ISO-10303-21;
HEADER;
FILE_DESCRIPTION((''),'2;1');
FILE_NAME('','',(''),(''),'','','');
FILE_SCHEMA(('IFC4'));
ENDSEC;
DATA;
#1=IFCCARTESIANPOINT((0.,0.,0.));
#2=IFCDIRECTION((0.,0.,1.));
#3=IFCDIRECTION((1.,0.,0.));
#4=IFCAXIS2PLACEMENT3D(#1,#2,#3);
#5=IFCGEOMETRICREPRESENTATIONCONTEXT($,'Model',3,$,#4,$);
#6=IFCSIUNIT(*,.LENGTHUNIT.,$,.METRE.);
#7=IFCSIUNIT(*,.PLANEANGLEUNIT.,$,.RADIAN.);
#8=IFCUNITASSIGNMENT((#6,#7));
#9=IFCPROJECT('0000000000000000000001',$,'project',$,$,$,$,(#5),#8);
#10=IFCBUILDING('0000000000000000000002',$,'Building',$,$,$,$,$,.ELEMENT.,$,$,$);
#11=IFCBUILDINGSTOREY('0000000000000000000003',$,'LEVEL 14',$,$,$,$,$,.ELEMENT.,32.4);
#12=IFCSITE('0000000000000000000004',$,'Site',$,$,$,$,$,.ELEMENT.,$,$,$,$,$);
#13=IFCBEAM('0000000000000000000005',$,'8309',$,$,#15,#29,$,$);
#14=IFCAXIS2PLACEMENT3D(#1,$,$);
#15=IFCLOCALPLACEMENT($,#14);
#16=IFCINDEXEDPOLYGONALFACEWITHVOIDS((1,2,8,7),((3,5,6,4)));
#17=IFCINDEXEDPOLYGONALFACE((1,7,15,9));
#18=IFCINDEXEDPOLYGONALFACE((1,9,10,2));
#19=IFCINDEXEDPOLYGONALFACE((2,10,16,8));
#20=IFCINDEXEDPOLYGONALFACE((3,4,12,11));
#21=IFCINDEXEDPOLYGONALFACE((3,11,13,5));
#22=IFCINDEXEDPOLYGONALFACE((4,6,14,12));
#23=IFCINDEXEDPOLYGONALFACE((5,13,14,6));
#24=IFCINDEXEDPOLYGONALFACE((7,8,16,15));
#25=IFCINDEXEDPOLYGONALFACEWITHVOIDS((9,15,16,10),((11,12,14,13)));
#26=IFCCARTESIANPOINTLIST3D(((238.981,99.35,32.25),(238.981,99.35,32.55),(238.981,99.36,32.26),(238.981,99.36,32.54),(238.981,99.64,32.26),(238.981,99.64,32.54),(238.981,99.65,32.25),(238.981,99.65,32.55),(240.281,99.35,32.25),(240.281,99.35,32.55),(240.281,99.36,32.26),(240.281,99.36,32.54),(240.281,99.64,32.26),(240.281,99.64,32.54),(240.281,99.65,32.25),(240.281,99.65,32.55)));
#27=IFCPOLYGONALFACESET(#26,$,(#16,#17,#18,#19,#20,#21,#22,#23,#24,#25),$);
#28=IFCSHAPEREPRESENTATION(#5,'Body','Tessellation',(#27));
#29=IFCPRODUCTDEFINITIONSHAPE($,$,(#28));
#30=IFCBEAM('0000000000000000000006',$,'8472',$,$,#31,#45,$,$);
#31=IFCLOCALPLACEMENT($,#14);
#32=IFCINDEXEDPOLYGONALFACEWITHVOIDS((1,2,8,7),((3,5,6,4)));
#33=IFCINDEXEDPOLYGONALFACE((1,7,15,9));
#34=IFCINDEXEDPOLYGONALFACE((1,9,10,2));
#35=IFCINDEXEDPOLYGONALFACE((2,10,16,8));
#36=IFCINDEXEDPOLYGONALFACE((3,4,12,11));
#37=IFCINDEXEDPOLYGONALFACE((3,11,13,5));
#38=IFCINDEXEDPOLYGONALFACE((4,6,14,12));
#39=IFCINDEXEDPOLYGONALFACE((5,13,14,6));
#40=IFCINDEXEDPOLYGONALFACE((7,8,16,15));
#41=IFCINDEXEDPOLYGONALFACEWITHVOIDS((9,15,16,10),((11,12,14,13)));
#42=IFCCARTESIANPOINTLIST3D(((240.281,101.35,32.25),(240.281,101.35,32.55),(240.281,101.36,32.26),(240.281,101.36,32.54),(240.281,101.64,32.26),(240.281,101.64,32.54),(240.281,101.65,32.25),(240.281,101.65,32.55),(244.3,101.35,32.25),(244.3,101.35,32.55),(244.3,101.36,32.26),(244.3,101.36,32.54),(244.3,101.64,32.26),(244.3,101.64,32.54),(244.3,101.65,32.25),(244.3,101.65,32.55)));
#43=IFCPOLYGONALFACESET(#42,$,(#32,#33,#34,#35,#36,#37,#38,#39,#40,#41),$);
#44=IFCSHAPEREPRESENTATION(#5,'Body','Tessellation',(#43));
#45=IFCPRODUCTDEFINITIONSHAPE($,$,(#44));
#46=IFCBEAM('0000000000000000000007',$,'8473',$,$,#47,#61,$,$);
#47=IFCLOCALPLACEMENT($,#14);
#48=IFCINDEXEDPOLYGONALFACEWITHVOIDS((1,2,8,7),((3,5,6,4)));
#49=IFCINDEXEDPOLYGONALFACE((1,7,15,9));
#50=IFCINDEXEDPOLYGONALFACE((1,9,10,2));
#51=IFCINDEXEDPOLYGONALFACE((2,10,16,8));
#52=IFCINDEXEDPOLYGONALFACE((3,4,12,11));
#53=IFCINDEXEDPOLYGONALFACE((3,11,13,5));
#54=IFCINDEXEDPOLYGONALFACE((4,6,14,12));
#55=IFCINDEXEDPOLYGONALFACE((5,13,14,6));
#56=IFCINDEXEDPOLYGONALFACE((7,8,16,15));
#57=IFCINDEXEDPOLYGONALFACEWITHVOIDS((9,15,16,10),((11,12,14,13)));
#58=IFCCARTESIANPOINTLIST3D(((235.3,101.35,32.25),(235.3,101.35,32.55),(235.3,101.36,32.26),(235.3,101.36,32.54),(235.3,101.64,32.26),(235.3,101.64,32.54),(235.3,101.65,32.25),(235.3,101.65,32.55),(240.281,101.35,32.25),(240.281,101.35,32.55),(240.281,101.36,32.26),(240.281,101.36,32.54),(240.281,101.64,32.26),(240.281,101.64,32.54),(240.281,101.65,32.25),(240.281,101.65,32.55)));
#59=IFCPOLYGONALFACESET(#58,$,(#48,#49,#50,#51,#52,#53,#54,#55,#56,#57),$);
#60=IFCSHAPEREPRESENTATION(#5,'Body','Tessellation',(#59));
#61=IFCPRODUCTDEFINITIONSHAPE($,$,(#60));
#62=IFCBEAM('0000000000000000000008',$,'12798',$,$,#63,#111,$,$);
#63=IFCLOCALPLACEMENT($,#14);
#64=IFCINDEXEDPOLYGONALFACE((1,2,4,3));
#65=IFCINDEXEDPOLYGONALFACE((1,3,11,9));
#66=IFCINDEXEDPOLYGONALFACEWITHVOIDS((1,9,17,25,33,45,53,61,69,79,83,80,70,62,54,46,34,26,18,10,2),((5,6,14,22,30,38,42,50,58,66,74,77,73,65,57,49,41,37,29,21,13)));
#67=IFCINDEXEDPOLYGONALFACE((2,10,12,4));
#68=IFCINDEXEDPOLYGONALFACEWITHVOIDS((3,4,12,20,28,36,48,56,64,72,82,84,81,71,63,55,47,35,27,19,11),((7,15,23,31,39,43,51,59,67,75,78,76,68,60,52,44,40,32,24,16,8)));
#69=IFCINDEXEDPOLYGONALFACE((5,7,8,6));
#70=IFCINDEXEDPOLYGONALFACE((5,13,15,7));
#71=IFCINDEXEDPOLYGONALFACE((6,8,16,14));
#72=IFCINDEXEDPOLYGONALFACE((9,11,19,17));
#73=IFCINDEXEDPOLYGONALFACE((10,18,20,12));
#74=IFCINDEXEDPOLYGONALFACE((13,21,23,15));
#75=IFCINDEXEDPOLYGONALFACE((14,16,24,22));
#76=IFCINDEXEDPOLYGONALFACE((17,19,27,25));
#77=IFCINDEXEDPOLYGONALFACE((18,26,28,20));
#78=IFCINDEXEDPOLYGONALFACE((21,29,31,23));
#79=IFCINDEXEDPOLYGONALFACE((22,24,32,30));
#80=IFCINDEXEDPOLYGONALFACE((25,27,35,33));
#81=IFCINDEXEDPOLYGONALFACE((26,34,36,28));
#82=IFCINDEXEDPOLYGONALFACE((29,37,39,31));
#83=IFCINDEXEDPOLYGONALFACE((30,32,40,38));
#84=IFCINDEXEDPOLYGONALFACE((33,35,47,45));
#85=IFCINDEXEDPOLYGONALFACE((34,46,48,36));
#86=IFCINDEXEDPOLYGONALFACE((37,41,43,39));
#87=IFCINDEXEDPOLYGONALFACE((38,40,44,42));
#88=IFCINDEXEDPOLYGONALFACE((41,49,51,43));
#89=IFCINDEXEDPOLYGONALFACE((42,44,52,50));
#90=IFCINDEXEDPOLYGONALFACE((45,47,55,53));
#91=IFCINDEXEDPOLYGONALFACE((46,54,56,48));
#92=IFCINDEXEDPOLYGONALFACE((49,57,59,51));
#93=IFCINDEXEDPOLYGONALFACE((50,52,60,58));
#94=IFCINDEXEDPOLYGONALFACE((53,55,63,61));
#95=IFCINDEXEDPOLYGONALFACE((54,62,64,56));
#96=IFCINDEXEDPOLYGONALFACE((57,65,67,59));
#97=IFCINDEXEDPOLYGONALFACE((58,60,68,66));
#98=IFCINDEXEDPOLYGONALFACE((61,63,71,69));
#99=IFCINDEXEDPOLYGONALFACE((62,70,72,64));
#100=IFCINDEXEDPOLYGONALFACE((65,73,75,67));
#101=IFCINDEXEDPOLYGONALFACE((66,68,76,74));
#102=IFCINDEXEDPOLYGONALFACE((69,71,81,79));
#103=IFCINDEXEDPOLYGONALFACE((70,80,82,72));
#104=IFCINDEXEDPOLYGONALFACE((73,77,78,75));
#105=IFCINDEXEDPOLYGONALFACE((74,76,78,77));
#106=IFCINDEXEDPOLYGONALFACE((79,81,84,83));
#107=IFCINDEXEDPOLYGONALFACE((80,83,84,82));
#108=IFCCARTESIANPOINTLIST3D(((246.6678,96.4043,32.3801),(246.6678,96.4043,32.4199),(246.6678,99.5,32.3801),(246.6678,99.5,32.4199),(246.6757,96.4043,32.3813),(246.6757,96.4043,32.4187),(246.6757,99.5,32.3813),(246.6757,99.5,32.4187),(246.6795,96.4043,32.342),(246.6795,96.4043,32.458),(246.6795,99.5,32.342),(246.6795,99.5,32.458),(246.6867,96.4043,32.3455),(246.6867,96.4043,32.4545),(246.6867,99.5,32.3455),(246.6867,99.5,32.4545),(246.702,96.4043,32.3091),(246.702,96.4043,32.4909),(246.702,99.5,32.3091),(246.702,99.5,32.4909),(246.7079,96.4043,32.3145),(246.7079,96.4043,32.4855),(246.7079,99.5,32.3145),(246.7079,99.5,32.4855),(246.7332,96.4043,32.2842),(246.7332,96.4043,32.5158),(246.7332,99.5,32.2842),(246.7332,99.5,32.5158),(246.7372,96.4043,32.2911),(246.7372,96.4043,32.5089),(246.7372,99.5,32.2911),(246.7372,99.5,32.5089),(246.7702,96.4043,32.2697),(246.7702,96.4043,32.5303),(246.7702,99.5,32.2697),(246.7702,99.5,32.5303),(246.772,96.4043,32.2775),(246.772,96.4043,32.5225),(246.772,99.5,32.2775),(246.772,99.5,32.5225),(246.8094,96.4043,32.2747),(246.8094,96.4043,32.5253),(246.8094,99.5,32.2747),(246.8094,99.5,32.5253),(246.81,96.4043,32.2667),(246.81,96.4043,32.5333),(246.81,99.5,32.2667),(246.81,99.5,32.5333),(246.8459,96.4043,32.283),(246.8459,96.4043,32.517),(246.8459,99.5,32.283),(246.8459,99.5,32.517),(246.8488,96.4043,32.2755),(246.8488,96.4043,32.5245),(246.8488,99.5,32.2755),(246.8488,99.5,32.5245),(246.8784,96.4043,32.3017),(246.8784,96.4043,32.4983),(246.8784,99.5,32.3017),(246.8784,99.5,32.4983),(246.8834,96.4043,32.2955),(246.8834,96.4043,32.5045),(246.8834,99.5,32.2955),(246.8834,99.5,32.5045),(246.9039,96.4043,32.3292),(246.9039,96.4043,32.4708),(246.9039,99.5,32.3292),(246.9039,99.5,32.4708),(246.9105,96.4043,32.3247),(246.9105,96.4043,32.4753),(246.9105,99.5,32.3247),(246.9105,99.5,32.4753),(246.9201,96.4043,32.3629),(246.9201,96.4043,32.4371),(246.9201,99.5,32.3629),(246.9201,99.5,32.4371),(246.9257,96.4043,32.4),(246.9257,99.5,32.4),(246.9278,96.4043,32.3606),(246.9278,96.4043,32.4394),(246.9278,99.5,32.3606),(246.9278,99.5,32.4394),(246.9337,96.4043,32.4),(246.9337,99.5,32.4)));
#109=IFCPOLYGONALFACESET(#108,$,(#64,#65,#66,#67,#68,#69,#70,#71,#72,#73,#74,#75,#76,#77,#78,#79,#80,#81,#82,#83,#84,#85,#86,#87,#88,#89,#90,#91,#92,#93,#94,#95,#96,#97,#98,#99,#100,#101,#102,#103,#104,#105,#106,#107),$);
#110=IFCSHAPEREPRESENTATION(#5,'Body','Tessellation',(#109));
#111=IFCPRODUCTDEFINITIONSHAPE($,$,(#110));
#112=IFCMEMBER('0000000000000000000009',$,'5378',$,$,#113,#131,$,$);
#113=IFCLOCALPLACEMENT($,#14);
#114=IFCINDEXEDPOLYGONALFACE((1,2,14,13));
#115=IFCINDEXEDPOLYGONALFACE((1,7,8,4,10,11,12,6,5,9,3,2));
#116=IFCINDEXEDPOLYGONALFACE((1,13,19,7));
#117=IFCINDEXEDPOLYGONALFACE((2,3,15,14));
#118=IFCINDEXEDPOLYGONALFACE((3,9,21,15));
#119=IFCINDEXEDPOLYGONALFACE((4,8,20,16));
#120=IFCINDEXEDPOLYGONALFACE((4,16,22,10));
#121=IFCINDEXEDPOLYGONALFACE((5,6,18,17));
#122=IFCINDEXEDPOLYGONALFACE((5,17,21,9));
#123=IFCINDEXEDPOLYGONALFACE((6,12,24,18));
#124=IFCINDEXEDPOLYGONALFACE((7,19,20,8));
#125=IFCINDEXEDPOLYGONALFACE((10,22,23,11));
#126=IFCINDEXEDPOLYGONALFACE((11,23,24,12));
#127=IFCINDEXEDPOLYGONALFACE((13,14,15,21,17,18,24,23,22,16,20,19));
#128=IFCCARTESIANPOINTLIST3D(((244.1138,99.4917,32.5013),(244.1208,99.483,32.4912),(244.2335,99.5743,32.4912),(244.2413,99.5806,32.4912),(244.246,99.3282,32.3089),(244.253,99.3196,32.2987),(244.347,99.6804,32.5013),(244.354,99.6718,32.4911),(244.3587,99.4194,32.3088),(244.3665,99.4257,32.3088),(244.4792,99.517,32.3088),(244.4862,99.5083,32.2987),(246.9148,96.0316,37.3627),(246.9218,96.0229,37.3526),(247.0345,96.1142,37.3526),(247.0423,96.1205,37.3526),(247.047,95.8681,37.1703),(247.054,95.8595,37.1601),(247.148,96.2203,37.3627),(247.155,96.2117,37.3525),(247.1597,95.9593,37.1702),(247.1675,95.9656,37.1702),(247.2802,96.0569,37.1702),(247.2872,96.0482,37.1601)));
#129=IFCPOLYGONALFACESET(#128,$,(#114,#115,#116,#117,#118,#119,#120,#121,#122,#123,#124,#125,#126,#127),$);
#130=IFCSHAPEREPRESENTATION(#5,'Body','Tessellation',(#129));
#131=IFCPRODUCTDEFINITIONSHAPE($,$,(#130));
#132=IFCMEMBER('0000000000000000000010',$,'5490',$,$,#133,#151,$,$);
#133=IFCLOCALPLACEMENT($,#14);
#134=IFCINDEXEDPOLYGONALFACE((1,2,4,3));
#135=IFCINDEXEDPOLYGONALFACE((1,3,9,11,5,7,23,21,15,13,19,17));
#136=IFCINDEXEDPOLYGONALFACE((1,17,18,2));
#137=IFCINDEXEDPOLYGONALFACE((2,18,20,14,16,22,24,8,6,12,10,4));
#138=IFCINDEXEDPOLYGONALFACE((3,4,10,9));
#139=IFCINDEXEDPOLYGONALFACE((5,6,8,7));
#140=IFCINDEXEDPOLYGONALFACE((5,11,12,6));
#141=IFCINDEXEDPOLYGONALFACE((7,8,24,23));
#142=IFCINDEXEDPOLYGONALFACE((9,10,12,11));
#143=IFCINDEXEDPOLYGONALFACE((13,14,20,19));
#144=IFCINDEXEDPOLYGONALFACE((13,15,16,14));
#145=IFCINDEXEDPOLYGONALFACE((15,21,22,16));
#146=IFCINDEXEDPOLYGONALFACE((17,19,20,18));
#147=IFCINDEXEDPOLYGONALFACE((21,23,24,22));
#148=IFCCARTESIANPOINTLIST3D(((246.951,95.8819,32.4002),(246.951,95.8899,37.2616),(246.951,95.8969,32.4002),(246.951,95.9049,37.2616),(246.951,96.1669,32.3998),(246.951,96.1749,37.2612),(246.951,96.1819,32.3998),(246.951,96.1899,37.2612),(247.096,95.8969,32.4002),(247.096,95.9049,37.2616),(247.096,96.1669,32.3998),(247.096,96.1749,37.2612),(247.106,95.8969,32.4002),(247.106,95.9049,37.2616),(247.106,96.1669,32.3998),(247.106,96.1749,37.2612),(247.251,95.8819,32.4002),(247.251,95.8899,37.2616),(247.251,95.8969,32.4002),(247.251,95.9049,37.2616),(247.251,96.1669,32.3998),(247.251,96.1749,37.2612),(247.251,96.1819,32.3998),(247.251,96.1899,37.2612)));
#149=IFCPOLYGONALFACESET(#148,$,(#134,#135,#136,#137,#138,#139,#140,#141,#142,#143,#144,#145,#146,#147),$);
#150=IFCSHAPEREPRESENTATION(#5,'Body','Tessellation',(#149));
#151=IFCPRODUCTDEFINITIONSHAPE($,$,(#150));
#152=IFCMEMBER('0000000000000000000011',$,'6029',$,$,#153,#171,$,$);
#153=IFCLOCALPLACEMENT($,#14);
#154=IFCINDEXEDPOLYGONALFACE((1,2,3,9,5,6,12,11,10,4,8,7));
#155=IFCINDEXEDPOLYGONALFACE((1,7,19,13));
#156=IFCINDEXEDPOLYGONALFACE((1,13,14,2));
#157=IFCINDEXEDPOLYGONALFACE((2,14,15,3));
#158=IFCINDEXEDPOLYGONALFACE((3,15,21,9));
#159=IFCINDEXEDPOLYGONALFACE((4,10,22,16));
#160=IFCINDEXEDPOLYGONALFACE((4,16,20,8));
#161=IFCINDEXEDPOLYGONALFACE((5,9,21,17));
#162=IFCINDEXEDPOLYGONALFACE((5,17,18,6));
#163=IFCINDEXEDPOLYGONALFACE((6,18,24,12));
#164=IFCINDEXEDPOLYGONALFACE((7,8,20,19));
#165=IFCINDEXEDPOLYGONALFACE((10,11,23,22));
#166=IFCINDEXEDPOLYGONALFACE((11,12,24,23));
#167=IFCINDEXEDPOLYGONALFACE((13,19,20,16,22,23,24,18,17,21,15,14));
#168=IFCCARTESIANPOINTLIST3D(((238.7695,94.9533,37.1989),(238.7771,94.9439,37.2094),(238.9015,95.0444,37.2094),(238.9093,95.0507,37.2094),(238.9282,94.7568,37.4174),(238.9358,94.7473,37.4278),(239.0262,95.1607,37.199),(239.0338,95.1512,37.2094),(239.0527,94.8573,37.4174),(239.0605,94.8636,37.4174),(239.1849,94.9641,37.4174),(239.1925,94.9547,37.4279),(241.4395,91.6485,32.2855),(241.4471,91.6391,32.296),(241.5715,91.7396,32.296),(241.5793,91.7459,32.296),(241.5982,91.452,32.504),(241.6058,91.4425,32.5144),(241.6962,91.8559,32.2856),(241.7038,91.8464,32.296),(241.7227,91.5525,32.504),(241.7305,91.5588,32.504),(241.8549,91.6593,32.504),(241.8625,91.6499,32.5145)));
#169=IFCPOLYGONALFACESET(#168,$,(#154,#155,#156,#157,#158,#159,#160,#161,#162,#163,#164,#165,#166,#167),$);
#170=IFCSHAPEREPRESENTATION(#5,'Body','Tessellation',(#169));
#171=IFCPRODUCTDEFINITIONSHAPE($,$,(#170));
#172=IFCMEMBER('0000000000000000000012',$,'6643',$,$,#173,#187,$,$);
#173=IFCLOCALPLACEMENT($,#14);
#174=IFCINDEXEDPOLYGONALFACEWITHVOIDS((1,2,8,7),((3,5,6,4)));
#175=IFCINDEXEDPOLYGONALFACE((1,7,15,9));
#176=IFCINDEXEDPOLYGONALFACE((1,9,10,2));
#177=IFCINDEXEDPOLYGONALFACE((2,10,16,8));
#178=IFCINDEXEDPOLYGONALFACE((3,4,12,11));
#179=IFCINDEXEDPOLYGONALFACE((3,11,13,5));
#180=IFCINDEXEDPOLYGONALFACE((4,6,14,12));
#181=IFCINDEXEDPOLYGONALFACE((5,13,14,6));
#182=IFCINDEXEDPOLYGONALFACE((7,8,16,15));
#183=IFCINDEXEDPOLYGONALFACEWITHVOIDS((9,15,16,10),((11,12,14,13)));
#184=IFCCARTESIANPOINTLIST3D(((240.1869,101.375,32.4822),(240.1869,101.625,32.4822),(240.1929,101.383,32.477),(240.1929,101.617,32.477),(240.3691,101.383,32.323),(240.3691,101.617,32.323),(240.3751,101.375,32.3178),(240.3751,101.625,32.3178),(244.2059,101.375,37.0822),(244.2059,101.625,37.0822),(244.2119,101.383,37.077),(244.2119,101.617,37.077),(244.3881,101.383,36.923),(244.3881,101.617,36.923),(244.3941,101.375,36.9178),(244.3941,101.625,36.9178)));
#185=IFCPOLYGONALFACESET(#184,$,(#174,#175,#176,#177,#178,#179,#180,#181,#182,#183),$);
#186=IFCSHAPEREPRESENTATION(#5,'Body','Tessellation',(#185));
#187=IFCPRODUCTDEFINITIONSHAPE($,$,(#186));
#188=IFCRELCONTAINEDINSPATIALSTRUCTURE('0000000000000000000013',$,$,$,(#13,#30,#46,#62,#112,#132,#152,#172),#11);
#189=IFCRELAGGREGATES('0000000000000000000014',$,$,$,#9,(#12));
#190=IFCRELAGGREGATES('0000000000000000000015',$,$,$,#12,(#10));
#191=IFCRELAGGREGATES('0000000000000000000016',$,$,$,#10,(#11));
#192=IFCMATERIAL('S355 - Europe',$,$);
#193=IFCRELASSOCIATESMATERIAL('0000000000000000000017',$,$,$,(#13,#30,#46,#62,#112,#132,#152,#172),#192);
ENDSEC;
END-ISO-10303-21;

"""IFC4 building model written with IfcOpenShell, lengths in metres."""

from ifc_helpers import new_model, si_unit, frame, origin_with_axes, origin_2d_with_axis, place, context, project, spatial, hollow_rectangle, hollow_circle, i_section, extrude, material, material_profile, profile_set, profile_usage, element, save


model = new_model("IFC4")

# Units and contexts
model_context = context("Model", 3, world=origin_with_axes())
ifc_project = project(units=[si_unit("LENGTHUNIT", "METRE"), si_unit("PLANEANGLEUNIT", "RADIAN")], contexts=[model_context])

# Site, building, storey
site = spatial("IfcSite", under=ifc_project, Name="Site", CompositionType="ELEMENT")
building = spatial("IfcBuilding", under=site, Name="Building", CompositionType="ELEMENT")
storey = spatial("IfcBuildingStorey", under=building, Name="LEVEL 14", CompositionType="ELEMENT", Elevation=32.4)

# Shared definitions
ifc_material = material(Name="S355 - Europe")

# Beams
ifc_material_profile_1 = material_profile(ifc_material, hollow_rectangle(XDim=0.3, YDim=0.3, WallThickness=0.01, at=origin_2d_with_axis()))
ifc_profile_set_1 = profile_set([ifc_material_profile_1])
ifc_profile_usage_1 = profile_usage(ifc_profile_set_1, cardinal=10)
beam_1_placement = place(None, frame((240.281, 99.5, 32.4), z_axis=(-1.0, 0.0, 0.0), x_axis=(0.0, -1.0, 0.0)))
element("IfcBeam", 1, at=beam_1_placement, inside=storey, material=ifc_profile_usage_1, Name="8309", context=model_context, shape_type="SweptSolid", body=[
    extrude(hollow_rectangle(XDim=0.3, YDim=0.3, WallThickness=0.01, at=origin_2d_with_axis()), origin_with_axes(), (0.0, 0.0, 1.0), 1.3),
])
ifc_material_profile_2 = material_profile(ifc_material, hollow_rectangle(XDim=0.3, YDim=0.3, WallThickness=0.01, at=origin_2d_with_axis()))
ifc_profile_set_2 = profile_set([ifc_material_profile_2])
ifc_profile_usage_2 = profile_usage(ifc_profile_set_2, cardinal=10)
beam_2_placement = place(None, frame((244.3, 101.5, 32.4), z_axis=(-1.0, 0.0, 0.0), x_axis=(0.0, -1.0, 0.0)))
element("IfcBeam", 2, at=beam_2_placement, inside=storey, material=ifc_profile_usage_2, Name="8472", context=model_context, shape_type="SweptSolid", body=[
    extrude(hollow_rectangle(XDim=0.3, YDim=0.3, WallThickness=0.01, at=origin_2d_with_axis()), origin_with_axes(), (0.0, 0.0, 1.0), 4.019),
])
ifc_material_profile_3 = material_profile(ifc_material, hollow_rectangle(XDim=0.3, YDim=0.3, WallThickness=0.01, at=origin_2d_with_axis()))
ifc_profile_set_3 = profile_set([ifc_material_profile_3])
ifc_profile_usage_3 = profile_usage(ifc_profile_set_3, cardinal=10)
beam_3_placement = place(None, frame((240.281, 101.5, 32.4), z_axis=(-1.0, 0.0, 0.0), x_axis=(0.0, -1.0, 0.0)))
element("IfcBeam", 3, at=beam_3_placement, inside=storey, material=ifc_profile_usage_3, Name="8473", context=model_context, shape_type="SweptSolid", body=[
    extrude(hollow_rectangle(XDim=0.3, YDim=0.3, WallThickness=0.01, at=origin_2d_with_axis()), origin_with_axes(), (0.0, 0.0, 1.0), 4.981),
])
ifc_material_profile_4 = material_profile(ifc_material, hollow_circle(Radius=0.1337, WallThickness=0.008, at=origin_2d_with_axis()))
ifc_profile_set_4 = profile_set([ifc_material_profile_4])
ifc_profile_usage_4 = profile_usage(ifc_profile_set_4, cardinal=10)
beam_4_placement = place(None, frame((246.8, 99.5, 32.4), z_axis=(0.0, -1.0, 0.0), x_axis=(1.0, 0.0, 0.0)))
element("IfcBeam", 4, at=beam_4_placement, inside=storey, material=ifc_profile_usage_4, Name="12798", context=model_context, shape_type="SweptSolid", body=[
    extrude(hollow_circle(Radius=0.1337, WallThickness=0.008, at=origin_2d_with_axis()), origin_with_axes(), (0.0, 0.0, 1.0), 3.0957),
])

# Members
ifc_material_profile_5 = material_profile(ifc_material, i_section(OverallWidth=0.3, OverallDepth=0.3, WebThickness=0.01, FlangeThickness=0.015, at=origin_2d_with_axis()))
ifc_profile_set_5 = profile_set([ifc_material_profile_5])
ifc_profile_usage_5 = profile_usage(ifc_profile_set_5, cardinal=10)
member_1_placement = place(None, frame((247.101, 96.0399, 37.2614), z_axis=(-0.424925, 0.524914, -0.737498), x_axis=(-0.77747, -0.62892, 0.0)))
element("IfcMember", 5, at=member_1_placement, inside=storey, material=ifc_profile_usage_5, Name="5378", context=model_context, shape_type="SweptSolid", body=[
    extrude(i_section(OverallWidth=0.3, OverallDepth=0.3, WebThickness=0.01, FlangeThickness=0.015, at=origin_2d_with_axis()), origin_with_axes(), (0.0, 0.0, 1.0), 6.5917),
])
ifc_material_profile_6 = material_profile(ifc_material, i_section(OverallWidth=0.3, OverallDepth=0.3, WebThickness=0.01, FlangeThickness=0.015, at=origin_2d_with_axis()))
ifc_profile_set_6 = profile_set([ifc_material_profile_6])
ifc_profile_usage_6 = profile_usage(ifc_profile_set_6, cardinal=10)
member_2_placement = place(None, frame((247.101, 96.0319, 32.4), z_axis=(0.0, 0.001646, 0.999999), x_axis=(-1.0, 0.0, 0.0)))
element("IfcMember", 6, at=member_2_placement, inside=storey, material=ifc_profile_usage_6, Name="5490", context=model_context, shape_type="SweptSolid", body=[
    extrude(i_section(OverallWidth=0.3, OverallDepth=0.3, WebThickness=0.01, FlangeThickness=0.015, at=origin_2d_with_axis()), origin_with_axes(), (0.0, 0.0, 1.0), 4.8614),
])
ifc_material_profile_7 = material_profile(ifc_material, i_section(OverallWidth=0.33, OverallDepth=0.35, WebThickness=0.01, FlangeThickness=0.016, at=origin_2d_with_axis()))
ifc_profile_set_7 = profile_set([ifc_material_profile_7])
ifc_profile_usage_7 = profile_usage(ifc_profile_set_7, cardinal=10)
member_3_placement = place(None, frame((241.651, 91.6492, 32.4), z_axis=(-0.411051, 0.508779, 0.756426), x_axis=(-0.777987, -0.62828, 0.0)))
element("IfcMember", 7, at=member_3_placement, inside=storey, material=ifc_profile_usage_7, Name="6029", context=model_context, shape_type="SweptSolid", body=[
    extrude(i_section(OverallWidth=0.33, OverallDepth=0.35, WebThickness=0.01, FlangeThickness=0.016, at=origin_2d_with_axis()), origin_with_axes(), (0.0, 0.0, 1.0), 6.4955),
])
ifc_material_profile_8 = material_profile(ifc_material, hollow_rectangle(XDim=0.25, YDim=0.25, WallThickness=0.008, at=origin_2d_with_axis()))
ifc_profile_set_8 = profile_set([ifc_material_profile_8])
ifc_profile_usage_8 = profile_usage(ifc_profile_set_8, cardinal=10)
member_4_placement = place(None, frame((240.281, 101.5, 32.4), z_axis=(0.657948, 0.0, 0.753063), x_axis=(0.0, 1.0, 0.0)))
element("IfcMember", 8, at=member_4_placement, inside=storey, material=ifc_profile_usage_8, Name="6643", context=model_context, shape_type="SweptSolid", body=[
    extrude(hollow_rectangle(XDim=0.25, YDim=0.25, WallThickness=0.008, at=origin_2d_with_axis()), origin_with_axes(), (0.0, 0.0, 1.0), 6.1084),
])

save(model, "model.ifc")
